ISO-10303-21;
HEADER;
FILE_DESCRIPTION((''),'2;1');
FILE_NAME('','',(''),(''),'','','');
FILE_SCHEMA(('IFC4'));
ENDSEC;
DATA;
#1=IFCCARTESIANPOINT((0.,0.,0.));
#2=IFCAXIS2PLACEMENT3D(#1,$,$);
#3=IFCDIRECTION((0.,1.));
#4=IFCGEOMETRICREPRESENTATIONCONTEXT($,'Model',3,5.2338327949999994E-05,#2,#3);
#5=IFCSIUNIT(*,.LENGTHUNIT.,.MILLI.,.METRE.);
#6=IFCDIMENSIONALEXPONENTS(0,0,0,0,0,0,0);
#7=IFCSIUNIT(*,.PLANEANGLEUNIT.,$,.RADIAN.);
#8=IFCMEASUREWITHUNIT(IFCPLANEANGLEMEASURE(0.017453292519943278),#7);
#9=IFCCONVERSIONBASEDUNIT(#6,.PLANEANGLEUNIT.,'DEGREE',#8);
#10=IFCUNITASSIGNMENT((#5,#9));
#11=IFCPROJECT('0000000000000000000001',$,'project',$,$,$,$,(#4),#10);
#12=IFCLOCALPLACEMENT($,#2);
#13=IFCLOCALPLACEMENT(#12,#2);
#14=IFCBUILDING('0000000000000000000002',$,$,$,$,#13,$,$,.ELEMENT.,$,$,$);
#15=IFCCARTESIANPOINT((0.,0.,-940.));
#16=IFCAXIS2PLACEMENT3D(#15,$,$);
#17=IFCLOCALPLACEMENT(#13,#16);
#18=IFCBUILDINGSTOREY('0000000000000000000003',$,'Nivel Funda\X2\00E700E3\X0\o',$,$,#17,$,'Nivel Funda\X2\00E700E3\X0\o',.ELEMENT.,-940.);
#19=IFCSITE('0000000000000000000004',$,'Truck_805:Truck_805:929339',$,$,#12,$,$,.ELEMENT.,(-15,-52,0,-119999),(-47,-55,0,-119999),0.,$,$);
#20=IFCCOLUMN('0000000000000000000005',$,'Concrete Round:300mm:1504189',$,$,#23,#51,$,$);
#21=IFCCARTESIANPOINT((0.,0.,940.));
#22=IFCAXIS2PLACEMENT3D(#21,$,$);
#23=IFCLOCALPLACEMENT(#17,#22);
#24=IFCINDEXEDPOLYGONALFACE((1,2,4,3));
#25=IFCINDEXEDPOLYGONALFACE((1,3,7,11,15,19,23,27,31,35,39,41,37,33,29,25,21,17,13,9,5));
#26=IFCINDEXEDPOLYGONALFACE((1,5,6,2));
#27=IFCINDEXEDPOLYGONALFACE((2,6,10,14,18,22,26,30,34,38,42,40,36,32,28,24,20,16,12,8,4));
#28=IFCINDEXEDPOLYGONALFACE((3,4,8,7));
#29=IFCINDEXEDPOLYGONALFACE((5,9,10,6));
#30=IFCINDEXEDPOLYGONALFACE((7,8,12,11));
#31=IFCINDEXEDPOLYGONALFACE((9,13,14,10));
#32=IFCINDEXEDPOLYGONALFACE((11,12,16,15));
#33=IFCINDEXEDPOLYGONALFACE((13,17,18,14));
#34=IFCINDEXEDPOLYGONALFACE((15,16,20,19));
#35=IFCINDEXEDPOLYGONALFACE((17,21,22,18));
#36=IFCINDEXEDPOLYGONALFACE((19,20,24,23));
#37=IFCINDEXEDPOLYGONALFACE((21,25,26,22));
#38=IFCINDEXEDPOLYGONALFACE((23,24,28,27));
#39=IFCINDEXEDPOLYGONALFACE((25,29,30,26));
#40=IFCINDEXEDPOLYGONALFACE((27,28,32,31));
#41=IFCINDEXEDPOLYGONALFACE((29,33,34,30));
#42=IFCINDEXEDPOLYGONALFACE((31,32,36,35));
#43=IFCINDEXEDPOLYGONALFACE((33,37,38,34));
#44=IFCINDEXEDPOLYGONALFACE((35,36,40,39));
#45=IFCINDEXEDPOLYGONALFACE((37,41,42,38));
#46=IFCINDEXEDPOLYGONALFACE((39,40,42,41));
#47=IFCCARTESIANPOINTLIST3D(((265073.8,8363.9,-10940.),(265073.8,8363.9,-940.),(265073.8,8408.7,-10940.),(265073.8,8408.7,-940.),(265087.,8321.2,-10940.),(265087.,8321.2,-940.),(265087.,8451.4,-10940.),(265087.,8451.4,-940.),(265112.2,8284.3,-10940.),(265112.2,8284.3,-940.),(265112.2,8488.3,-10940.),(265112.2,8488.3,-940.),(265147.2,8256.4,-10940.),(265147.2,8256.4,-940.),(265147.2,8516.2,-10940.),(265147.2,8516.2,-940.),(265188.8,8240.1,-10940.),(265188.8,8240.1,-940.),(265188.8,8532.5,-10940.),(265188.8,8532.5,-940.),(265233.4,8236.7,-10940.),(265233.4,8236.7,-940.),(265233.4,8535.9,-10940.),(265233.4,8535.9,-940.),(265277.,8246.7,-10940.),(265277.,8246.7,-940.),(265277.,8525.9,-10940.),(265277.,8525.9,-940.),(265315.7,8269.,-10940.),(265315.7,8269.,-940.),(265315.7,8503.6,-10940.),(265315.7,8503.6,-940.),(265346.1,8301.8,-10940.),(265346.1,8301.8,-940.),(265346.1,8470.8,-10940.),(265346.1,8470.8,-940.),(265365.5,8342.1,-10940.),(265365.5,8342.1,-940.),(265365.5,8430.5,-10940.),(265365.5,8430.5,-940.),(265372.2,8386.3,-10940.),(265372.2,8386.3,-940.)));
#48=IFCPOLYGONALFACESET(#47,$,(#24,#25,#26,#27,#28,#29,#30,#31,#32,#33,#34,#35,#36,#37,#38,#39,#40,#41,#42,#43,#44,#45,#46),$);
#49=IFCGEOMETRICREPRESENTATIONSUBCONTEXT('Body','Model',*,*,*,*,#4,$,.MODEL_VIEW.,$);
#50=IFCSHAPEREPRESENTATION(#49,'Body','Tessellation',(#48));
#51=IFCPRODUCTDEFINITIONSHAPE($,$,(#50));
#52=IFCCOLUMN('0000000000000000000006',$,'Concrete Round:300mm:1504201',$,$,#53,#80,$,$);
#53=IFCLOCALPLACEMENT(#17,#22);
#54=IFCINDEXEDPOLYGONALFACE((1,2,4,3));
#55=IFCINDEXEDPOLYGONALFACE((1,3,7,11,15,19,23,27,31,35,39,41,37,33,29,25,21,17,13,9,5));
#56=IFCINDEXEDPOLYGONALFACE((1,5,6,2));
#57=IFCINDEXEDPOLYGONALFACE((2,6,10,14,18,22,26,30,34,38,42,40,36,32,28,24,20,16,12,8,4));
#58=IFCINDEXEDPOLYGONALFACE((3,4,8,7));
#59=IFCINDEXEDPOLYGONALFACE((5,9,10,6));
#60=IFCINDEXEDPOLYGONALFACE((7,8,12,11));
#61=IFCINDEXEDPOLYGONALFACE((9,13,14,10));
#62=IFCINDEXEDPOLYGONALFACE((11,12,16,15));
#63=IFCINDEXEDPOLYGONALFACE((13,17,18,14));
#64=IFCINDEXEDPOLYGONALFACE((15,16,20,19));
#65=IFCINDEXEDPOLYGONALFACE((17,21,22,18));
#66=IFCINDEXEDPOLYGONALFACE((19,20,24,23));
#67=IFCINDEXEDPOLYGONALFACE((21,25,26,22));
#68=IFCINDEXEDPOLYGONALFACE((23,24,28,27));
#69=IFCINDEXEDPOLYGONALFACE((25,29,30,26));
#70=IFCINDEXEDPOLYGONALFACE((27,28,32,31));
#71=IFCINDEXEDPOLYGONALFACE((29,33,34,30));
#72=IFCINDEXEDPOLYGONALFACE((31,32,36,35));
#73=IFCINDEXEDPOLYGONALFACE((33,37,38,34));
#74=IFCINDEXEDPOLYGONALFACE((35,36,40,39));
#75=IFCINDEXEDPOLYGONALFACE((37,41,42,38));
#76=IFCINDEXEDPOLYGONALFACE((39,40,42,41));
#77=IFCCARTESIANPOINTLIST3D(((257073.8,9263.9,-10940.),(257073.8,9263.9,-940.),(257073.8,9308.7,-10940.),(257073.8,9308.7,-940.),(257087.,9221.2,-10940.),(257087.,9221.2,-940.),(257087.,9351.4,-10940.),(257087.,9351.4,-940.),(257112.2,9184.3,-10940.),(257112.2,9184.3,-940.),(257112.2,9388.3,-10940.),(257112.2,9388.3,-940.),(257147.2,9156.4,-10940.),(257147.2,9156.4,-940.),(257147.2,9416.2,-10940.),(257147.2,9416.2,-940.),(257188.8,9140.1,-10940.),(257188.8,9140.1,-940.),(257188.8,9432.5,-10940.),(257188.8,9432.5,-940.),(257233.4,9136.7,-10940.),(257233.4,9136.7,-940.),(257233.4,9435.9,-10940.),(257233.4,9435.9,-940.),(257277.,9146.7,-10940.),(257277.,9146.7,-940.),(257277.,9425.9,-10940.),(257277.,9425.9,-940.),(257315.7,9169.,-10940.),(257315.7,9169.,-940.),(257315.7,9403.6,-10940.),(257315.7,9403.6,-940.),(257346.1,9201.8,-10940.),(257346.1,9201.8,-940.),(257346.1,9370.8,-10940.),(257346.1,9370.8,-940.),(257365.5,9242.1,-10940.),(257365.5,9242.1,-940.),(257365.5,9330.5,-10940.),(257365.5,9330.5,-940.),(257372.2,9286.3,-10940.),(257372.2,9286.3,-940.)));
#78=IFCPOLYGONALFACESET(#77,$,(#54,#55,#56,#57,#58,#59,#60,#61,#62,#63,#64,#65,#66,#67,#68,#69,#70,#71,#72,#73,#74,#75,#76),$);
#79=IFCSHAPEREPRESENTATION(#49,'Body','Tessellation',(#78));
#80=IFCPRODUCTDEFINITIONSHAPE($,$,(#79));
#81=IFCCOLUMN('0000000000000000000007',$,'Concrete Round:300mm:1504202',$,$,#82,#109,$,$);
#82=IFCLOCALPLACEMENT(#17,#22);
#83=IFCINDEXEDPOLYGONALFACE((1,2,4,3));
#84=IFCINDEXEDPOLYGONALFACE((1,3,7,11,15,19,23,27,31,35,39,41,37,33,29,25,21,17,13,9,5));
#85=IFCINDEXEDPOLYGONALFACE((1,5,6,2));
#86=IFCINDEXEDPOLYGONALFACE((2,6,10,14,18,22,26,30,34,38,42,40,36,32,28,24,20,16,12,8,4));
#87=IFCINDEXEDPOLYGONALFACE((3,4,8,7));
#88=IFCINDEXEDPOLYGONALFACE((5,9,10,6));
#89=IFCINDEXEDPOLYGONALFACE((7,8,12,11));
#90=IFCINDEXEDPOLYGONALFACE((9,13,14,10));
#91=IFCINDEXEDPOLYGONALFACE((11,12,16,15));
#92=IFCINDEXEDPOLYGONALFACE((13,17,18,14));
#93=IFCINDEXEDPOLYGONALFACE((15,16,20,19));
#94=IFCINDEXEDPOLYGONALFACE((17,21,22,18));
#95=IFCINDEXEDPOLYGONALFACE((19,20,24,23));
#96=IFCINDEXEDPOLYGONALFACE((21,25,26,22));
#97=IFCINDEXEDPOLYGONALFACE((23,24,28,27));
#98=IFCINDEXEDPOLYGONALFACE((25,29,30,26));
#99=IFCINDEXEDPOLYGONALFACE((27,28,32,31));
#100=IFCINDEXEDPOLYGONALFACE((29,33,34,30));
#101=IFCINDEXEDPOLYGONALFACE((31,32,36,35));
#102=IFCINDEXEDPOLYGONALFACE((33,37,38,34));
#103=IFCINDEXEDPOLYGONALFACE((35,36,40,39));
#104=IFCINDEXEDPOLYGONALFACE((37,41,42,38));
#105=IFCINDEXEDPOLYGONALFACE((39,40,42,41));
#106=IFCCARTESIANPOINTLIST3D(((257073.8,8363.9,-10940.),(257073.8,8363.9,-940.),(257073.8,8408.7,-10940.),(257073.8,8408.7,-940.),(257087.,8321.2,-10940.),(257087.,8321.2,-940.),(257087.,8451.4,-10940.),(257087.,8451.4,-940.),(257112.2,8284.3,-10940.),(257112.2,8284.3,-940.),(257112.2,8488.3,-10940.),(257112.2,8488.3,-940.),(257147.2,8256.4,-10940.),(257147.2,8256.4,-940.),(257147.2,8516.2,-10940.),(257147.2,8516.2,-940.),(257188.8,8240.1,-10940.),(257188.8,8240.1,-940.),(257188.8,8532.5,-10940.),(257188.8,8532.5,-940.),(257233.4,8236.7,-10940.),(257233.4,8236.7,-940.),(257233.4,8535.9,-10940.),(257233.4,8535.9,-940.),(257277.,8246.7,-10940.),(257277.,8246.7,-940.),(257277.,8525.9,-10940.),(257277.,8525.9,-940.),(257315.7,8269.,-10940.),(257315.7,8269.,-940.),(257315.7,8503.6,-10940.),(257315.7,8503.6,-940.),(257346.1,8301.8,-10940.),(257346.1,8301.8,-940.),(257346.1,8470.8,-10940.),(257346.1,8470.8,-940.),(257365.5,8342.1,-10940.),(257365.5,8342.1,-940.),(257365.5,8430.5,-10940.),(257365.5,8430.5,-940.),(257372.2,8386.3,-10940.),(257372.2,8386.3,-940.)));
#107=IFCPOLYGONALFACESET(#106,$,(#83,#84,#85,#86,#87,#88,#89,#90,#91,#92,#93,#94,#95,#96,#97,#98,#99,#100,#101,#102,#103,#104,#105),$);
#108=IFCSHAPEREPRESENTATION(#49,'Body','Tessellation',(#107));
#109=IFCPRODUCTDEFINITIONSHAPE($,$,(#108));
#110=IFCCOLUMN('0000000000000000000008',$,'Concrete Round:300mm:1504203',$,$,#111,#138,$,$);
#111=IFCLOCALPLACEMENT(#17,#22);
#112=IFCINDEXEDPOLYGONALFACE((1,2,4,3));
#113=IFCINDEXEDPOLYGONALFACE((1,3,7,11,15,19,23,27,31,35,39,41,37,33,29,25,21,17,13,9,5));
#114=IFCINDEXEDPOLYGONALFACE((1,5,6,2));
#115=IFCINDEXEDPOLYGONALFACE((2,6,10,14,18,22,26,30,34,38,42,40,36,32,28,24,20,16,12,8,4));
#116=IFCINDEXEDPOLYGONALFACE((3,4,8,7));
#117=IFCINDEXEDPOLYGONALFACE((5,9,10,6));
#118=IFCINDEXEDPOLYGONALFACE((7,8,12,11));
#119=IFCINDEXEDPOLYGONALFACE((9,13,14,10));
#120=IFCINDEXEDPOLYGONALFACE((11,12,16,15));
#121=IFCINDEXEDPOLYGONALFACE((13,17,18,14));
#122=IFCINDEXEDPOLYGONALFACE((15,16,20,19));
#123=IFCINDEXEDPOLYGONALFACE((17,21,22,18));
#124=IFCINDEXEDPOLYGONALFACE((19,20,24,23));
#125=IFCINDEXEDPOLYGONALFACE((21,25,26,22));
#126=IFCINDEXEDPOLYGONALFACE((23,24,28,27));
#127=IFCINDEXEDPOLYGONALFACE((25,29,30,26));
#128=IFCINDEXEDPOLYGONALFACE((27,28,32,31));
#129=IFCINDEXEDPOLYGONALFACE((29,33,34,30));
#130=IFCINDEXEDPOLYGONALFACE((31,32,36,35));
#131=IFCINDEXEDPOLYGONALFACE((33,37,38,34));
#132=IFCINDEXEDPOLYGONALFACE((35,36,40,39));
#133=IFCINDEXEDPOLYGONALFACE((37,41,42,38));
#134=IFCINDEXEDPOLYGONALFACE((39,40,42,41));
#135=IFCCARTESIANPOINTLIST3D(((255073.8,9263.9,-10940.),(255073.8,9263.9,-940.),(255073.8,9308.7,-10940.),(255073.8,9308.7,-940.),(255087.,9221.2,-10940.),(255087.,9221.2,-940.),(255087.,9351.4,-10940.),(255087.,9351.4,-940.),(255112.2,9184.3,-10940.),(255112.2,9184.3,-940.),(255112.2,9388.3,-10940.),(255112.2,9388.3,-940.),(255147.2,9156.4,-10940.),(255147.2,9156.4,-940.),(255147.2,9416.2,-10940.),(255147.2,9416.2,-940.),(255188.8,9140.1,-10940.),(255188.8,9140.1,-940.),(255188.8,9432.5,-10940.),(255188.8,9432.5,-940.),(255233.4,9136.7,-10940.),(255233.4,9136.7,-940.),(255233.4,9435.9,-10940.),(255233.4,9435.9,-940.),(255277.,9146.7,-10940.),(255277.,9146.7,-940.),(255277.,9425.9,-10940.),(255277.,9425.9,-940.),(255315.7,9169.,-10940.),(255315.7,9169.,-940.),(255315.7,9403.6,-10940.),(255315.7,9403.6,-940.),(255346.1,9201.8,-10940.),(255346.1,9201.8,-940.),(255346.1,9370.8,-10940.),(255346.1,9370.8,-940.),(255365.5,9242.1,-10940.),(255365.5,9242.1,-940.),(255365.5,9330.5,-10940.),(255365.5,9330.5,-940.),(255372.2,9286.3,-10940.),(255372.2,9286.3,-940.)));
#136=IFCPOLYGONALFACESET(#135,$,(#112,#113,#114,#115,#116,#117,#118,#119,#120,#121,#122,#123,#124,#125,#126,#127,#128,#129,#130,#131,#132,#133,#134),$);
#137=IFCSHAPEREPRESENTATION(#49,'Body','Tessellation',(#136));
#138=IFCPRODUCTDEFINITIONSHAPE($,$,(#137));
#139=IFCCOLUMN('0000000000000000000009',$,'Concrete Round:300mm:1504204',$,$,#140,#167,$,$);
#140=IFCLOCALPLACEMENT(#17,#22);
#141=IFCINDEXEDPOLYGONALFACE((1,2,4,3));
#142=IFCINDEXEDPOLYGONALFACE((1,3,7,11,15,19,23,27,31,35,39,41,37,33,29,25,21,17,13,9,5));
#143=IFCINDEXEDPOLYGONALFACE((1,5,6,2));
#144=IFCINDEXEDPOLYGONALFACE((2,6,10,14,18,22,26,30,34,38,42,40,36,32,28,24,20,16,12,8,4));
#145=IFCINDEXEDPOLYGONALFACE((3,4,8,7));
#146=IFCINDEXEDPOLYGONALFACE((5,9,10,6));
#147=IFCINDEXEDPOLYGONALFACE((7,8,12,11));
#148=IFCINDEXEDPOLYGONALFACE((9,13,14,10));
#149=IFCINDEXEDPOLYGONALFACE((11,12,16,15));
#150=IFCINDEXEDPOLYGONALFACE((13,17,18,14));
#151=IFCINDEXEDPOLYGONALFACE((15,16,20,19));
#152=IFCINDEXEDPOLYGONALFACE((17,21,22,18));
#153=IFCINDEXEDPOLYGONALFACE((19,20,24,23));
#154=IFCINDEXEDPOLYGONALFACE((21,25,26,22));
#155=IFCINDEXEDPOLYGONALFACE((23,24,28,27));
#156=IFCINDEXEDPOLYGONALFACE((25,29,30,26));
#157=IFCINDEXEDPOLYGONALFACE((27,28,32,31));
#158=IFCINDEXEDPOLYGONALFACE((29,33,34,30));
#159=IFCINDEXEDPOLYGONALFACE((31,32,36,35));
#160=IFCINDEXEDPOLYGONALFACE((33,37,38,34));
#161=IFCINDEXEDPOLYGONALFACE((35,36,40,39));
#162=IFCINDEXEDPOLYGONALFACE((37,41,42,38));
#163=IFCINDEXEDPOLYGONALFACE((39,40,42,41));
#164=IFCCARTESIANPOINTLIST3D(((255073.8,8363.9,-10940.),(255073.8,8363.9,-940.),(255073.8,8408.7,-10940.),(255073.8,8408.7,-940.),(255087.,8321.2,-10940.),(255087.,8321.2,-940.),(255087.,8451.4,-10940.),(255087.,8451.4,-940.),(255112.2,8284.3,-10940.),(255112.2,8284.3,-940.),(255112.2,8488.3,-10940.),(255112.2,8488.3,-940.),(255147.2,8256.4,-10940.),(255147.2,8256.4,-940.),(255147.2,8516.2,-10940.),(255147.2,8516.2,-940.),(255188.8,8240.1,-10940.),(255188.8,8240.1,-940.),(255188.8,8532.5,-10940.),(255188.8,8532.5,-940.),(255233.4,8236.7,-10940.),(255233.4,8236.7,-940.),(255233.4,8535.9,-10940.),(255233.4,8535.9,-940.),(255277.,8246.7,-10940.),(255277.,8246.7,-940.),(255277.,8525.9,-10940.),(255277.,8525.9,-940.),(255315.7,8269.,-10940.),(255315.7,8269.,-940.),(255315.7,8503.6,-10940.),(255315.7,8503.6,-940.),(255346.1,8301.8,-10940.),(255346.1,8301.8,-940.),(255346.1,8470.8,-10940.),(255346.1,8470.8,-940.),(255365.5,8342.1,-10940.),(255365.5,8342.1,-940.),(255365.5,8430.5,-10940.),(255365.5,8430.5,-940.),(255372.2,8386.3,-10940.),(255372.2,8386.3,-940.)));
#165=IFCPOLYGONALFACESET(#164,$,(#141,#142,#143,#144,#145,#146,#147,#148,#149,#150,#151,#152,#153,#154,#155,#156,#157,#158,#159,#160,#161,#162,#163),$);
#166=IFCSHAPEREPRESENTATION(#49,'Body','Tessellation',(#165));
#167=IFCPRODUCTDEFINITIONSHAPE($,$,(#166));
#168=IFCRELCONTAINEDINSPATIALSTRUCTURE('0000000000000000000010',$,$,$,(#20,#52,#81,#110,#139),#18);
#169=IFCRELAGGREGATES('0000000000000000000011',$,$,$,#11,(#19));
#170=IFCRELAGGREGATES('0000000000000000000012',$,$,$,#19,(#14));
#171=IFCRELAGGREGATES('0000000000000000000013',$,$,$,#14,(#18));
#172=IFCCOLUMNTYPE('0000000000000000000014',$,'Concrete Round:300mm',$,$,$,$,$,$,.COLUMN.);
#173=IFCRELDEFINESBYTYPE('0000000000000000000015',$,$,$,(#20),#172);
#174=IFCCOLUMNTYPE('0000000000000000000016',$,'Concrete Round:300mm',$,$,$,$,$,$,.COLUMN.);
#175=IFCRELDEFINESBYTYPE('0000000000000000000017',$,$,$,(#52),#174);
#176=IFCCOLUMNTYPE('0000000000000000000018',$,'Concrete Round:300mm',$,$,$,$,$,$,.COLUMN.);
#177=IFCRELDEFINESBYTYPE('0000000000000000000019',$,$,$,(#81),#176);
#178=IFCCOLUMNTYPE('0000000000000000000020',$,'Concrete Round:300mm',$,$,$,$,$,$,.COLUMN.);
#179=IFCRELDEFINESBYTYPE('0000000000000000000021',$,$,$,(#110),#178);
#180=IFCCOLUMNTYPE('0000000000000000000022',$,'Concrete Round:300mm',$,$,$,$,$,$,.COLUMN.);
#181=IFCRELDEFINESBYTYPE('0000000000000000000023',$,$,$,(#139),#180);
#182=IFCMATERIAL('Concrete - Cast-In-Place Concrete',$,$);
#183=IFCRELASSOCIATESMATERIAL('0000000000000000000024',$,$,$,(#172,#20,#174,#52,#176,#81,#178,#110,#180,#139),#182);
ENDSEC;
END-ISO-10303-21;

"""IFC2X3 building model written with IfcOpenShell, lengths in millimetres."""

from ifc_helpers import new_model, entity, si_unit, converted_unit, direction, frame, origin, origin_2d_with_axis, place, context, subcontext, project, spatial, circle, extrude, source, transform, mapped, material, type_object, type_shapes, element, save


model = new_model("IFC2X3")

# Units and contexts
model_context = context("Model", 3, precision=5.2338327949999994e-05, world=origin(), true_north=direction((0.0, 1.0)))
body_context = subcontext(model_context, "Body", "Model", "MODEL_VIEW")
ifc_project = project(units=[si_unit("LENGTHUNIT", "METRE", prefix="MILLI"), converted_unit("PLANEANGLEUNIT", "DEGREE", entity("IfcPlaneAngleMeasure", 0.017453292519943278), si_unit("PLANEANGLEUNIT", "RADIAN"), dimensions=[0, 0, 0, 0, 0, 0, 0])], contexts=[model_context])

# Site, building, storey
site_placement = place(None, origin())
site = spatial("IfcSite", under=ifc_project, at=site_placement, Name="Truck_805:Truck_805:929339", CompositionType="ELEMENT", RefLatitude=(-15, -52, 0, -119999), RefLongitude=(-47, -55, 0, -119999), RefElevation=0.0)
building_placement = place(site_placement, origin())
building = spatial("IfcBuilding", under=site, at=building_placement, CompositionType="ELEMENT")
storey_placement = place(building_placement, frame((0.0, 0.0, -940.0)))
storey = spatial("IfcBuildingStorey", under=building, at=storey_placement, Name="Nivel Fundação", LongName="Nivel Fundação", CompositionType="ELEMENT", Elevation=-940.0)

# Columns
ifc_material = material(Name="Concrete - Cast-In-Place Concrete")
column_type_1 = type_object("IfcColumnType", Name="Concrete Round:300mm", PredefinedType="COLUMN", material=ifc_material)
shared_shape_1 = source(origin(), body_context, "Body", "SweptSolid", [
    extrude(circle(Radius=150.0, at=origin_2d_with_axis()), frame((265222.2, 8386.3, -10940.0)), (0.0, 0.0, 1.0), 10000.0),
])
type_shapes(column_type_1, [shared_shape_1])
column_1_placement = place(storey_placement, frame((0.0, 0.0, 940.0)))
element("IfcColumn", 1, at=column_1_placement, inside=storey, type_object=column_type_1, material=ifc_material, Name="Concrete Round:300mm:1504189", context=body_context, shape_type="MappedRepresentation", body=[
    mapped(shared_shape_1, transform((0.0, 0.0, 0.0), scale=1.0)),
])
column_type_2 = type_object("IfcColumnType", Name="Concrete Round:300mm", PredefinedType="COLUMN", material=ifc_material)
shared_shape_2 = source(origin(), body_context, "Body", "SweptSolid", [
    extrude(circle(Radius=150.0, at=origin_2d_with_axis()), frame((257222.2, 9286.3, -10940.0)), (0.0, 0.0, 1.0), 10000.0),
])
type_shapes(column_type_2, [shared_shape_2])
column_2_placement = place(storey_placement, frame((0.0, 0.0, 940.0)))
element("IfcColumn", 2, at=column_2_placement, inside=storey, type_object=column_type_2, material=ifc_material, Name="Concrete Round:300mm:1504201", context=body_context, shape_type="MappedRepresentation", body=[
    mapped(shared_shape_2, transform((0.0, 0.0, 0.0), scale=1.0)),
])
column_type_3 = type_object("IfcColumnType", Name="Concrete Round:300mm", PredefinedType="COLUMN", material=ifc_material)
shared_shape_3 = source(origin(), body_context, "Body", "SweptSolid", [
    extrude(circle(Radius=150.0, at=origin_2d_with_axis()), frame((257222.2, 8386.3, -10940.0)), (0.0, 0.0, 1.0), 10000.0),
])
type_shapes(column_type_3, [shared_shape_3])
column_3_placement = place(storey_placement, frame((0.0, 0.0, 940.0)))
element("IfcColumn", 3, at=column_3_placement, inside=storey, type_object=column_type_3, material=ifc_material, Name="Concrete Round:300mm:1504202", context=body_context, shape_type="MappedRepresentation", body=[
    mapped(shared_shape_3, transform((0.0, 0.0, 0.0), scale=1.0)),
])
column_type_4 = type_object("IfcColumnType", Name="Concrete Round:300mm", PredefinedType="COLUMN", material=ifc_material)
shared_shape_4 = source(origin(), body_context, "Body", "SweptSolid", [
    extrude(circle(Radius=150.0, at=origin_2d_with_axis()), frame((255222.2, 9286.3, -10940.0)), (0.0, 0.0, 1.0), 10000.0),
])
type_shapes(column_type_4, [shared_shape_4])
column_4_placement = place(storey_placement, frame((0.0, 0.0, 940.0)))
element("IfcColumn", 4, at=column_4_placement, inside=storey, type_object=column_type_4, material=ifc_material, Name="Concrete Round:300mm:1504203", context=body_context, shape_type="MappedRepresentation", body=[
    mapped(shared_shape_4, transform((0.0, 0.0, 0.0), scale=1.0)),
])
column_type_5 = type_object("IfcColumnType", Name="Concrete Round:300mm", PredefinedType="COLUMN", material=ifc_material)
shared_shape_5 = source(origin(), body_context, "Body", "SweptSolid", [
    extrude(circle(Radius=150.0, at=origin_2d_with_axis()), frame((255222.2, 8386.3, -10940.0)), (0.0, 0.0, 1.0), 10000.0),
])
type_shapes(column_type_5, [shared_shape_5])
column_5_placement = place(storey_placement, frame((0.0, 0.0, 940.0)))
element("IfcColumn", 5, at=column_5_placement, inside=storey, type_object=column_type_5, material=ifc_material, Name="Concrete Round:300mm:1504204", context=body_context, shape_type="MappedRepresentation", body=[
    mapped(shared_shape_5, transform((0.0, 0.0, 0.0), scale=1.0)),
])

save(model, "model.ifc")
